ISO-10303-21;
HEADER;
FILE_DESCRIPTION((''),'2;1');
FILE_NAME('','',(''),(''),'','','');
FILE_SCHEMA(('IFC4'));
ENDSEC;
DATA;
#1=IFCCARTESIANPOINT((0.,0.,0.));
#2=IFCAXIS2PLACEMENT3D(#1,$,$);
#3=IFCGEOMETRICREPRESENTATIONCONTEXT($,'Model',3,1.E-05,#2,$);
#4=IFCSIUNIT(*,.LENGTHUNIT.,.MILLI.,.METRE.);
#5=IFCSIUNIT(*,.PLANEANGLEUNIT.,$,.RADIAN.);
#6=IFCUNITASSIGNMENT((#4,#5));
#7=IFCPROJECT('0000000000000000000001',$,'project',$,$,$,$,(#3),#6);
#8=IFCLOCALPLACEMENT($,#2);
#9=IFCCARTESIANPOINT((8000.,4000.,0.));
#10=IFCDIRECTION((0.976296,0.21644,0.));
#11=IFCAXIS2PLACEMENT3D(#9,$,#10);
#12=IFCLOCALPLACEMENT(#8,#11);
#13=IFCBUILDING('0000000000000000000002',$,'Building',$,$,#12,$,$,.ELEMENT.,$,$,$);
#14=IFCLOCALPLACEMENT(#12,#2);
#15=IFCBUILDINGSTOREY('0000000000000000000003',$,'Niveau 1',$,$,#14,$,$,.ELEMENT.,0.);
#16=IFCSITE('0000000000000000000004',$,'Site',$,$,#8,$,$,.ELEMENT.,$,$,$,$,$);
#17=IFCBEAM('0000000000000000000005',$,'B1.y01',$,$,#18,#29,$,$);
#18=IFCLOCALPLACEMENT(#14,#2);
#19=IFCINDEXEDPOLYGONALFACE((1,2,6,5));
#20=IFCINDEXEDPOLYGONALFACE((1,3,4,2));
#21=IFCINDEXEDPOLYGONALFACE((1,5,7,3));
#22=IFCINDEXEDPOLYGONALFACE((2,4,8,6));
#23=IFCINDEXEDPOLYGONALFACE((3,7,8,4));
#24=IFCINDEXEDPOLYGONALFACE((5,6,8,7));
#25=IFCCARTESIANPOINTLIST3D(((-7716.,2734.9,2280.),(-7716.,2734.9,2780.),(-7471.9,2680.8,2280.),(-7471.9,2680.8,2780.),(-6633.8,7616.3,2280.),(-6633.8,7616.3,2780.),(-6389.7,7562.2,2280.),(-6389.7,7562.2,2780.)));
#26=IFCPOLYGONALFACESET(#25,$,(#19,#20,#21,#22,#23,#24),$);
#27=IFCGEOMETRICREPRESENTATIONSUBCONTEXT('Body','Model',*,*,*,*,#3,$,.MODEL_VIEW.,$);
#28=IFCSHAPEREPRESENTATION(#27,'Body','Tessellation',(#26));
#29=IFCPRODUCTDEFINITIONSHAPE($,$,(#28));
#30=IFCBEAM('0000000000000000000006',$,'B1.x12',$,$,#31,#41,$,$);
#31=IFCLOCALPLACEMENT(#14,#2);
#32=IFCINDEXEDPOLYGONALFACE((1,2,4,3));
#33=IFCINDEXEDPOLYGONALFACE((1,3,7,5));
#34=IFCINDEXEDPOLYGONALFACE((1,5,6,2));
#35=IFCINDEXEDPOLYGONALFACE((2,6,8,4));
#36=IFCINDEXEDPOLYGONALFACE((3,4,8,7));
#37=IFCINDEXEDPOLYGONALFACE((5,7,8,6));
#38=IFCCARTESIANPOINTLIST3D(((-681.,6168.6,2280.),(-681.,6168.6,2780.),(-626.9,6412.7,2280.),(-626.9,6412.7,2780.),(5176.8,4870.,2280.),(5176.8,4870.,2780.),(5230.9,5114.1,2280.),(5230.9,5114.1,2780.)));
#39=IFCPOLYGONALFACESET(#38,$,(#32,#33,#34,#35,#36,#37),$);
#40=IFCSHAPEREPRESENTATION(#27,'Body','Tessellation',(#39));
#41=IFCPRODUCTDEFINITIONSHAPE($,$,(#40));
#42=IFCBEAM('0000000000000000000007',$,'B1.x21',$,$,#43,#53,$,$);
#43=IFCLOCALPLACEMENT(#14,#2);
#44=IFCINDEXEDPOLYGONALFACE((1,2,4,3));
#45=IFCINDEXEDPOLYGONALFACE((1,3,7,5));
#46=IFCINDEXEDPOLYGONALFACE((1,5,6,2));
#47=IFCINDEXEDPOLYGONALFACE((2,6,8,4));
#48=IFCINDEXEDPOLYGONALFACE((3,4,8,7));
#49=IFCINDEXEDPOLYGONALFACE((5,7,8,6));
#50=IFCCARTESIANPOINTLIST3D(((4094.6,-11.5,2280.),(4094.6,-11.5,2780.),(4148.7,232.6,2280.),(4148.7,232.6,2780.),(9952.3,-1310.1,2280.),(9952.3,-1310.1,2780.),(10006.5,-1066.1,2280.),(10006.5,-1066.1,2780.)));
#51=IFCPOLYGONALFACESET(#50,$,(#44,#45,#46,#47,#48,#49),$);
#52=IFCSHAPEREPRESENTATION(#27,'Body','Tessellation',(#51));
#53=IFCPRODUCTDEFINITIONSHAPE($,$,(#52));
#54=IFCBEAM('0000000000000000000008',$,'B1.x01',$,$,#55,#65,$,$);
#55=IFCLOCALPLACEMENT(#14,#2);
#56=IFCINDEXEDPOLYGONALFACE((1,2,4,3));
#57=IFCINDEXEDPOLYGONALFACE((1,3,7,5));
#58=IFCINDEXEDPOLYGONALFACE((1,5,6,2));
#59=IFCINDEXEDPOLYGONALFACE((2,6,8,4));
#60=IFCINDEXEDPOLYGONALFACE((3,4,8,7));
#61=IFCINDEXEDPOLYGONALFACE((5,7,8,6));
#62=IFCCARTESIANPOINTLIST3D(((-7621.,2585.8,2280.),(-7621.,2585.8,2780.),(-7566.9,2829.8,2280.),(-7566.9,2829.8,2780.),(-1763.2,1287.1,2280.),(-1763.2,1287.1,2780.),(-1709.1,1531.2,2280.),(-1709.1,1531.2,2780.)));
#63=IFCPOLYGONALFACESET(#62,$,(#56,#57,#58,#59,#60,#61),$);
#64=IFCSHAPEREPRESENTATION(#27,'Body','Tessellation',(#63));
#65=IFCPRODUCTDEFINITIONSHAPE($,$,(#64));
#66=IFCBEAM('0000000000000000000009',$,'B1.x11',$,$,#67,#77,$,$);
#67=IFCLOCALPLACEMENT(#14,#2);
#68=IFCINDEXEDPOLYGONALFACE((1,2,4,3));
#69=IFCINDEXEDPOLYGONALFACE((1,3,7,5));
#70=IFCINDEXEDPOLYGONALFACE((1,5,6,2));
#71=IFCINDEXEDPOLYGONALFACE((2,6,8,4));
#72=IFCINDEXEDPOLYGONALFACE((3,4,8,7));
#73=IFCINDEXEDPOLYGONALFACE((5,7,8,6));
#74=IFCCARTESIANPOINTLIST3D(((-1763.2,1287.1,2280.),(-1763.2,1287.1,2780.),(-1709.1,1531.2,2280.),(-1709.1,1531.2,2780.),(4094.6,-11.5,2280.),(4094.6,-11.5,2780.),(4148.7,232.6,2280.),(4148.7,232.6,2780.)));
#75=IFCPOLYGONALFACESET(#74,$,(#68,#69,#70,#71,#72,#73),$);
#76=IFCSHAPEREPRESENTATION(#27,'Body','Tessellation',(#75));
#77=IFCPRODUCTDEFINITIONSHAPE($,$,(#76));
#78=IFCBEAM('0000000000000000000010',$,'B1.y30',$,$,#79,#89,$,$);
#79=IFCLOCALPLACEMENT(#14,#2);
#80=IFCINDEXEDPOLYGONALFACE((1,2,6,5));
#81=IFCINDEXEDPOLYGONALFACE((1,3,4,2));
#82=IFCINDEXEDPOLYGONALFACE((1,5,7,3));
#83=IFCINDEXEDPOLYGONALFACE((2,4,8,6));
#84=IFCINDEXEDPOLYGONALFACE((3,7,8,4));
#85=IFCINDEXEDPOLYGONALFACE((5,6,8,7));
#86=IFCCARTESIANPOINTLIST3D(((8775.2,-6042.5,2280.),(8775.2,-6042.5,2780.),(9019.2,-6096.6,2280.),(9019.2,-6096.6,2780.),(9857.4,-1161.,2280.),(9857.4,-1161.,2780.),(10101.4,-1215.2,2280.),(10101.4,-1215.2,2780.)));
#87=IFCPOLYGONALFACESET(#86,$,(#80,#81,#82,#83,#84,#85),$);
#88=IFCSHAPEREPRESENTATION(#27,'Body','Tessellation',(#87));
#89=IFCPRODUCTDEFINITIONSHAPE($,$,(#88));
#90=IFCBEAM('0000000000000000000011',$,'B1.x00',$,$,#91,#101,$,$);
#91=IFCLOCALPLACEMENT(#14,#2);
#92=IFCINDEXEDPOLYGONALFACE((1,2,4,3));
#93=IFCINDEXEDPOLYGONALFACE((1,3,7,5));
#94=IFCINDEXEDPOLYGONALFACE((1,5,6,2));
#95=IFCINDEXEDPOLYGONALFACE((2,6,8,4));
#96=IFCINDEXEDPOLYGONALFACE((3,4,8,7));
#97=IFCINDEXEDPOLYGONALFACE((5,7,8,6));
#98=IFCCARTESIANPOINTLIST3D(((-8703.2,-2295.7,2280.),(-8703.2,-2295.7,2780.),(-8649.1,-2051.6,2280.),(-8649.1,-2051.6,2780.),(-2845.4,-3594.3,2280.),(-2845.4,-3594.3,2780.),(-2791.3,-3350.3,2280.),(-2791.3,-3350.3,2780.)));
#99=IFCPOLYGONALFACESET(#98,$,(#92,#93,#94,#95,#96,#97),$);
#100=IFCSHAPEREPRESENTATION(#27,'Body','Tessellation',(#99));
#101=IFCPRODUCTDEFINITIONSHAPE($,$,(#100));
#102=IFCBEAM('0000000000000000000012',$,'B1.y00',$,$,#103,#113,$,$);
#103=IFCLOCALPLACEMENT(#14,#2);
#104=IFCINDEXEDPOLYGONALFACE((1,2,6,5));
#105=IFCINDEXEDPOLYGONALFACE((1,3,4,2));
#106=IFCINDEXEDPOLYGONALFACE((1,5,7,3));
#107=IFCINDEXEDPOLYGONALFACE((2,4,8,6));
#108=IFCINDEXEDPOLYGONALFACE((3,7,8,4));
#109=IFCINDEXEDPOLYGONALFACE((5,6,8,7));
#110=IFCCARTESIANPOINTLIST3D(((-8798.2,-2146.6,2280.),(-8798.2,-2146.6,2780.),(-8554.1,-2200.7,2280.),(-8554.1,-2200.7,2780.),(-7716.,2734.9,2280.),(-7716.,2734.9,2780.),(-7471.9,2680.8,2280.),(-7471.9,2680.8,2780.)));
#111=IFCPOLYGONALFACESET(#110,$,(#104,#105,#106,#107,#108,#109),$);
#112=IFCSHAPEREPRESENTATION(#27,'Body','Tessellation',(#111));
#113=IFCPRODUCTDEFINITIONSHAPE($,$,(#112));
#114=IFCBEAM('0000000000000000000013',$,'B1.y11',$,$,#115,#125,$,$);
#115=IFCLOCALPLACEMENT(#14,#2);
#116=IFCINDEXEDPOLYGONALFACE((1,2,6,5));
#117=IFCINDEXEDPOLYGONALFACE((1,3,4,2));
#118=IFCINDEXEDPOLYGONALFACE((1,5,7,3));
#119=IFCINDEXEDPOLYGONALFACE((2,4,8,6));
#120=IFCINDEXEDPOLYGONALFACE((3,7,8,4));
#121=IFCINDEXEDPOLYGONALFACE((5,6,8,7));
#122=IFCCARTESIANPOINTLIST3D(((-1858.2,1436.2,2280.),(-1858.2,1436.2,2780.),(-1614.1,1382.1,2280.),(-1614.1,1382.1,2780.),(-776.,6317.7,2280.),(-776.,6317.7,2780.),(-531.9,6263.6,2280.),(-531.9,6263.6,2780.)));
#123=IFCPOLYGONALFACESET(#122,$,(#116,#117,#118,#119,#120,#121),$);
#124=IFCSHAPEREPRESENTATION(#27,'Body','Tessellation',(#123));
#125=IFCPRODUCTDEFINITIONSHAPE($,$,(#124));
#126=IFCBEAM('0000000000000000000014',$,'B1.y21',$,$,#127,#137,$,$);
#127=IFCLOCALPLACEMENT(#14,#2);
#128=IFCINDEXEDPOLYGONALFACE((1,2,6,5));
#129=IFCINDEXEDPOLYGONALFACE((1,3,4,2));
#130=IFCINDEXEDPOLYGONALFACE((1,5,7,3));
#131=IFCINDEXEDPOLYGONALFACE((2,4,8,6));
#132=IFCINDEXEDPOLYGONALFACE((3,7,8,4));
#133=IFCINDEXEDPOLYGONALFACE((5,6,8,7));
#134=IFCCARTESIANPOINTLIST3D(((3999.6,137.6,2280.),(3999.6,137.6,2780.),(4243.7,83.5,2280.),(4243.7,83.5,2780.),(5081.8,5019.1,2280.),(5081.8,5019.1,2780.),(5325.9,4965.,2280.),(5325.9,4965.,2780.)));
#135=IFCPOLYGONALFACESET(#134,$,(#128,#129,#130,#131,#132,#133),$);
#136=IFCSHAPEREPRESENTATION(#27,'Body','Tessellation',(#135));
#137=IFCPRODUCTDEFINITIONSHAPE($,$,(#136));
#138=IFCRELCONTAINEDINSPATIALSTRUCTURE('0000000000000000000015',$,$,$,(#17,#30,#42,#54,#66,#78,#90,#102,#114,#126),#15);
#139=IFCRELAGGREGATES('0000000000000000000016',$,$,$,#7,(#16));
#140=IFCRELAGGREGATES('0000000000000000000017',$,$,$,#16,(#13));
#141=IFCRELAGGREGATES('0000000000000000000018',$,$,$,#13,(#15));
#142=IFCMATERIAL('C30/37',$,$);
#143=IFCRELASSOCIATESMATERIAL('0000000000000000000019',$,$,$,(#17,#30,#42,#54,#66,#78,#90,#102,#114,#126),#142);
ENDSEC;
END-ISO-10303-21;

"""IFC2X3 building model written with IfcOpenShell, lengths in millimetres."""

from ifc_helpers import new_model, si_unit, frame, origin, origin_2d, place, context, subcontext, project, spatial, rectangle, extrude, material, element, save


model = new_model("IFC2X3")

# Units and contexts
model_context = context("Model", 3, precision=1e-05, world=origin())
body_context = subcontext(model_context, "Body", "Model", "MODEL_VIEW")
ifc_project = project(units=[si_unit("LENGTHUNIT", "METRE", prefix="MILLI"), si_unit("PLANEANGLEUNIT", "RADIAN")], contexts=[model_context])

# Site, building, storey
site_placement = place(None, origin())
site = spatial("IfcSite", under=ifc_project, at=site_placement, Name="Site", CompositionType="ELEMENT")
building_placement = place(site_placement, frame((8000.0, 4000.0, 0.0), x_axis=(0.976296, 0.21644, 0.0)))
building = spatial("IfcBuilding", under=site, at=building_placement, Name="Building", CompositionType="ELEMENT")
storey_placement = place(building_placement, origin())
storey = spatial("IfcBuildingStorey", under=building, at=storey_placement, Name="Niveau 1", CompositionType="ELEMENT", Elevation=0.0)

# Shared definitions
ifc_material = material(Name="C30/37")

# Beams
beam_1_placement = place(storey_placement, frame((-7593.9, 2707.8, 2530.0), z_axis=(0.21644, 0.976296, 0.0), x_axis=(-0.976296, 0.21644, 0.0)))
element("IfcBeam", 1, at=beam_1_placement, inside=storey, material=ifc_material, Name="B1.y01", context=body_context, shape_type="SweptSolid", body=[
    extrude(rectangle(XDim=250.0, YDim=500.0, at=origin_2d()), origin(), (0.0, 0.0, 1.0), 5000.0),
])
for number, where, z_axis, x_axis, name in (
    (2, (-654.0, 6290.7, 2530.0), (0.976296, -0.21644, 0.0), (0.21644, 0.976296, 0.0), "B1.x12"),
    (3, (4121.6, 110.5, 2530.0), (0.976296, -0.21644, 0.0), (0.21644, 0.976296, 0.0), "B1.x21"),
    (4, (-7593.9, 2707.8, 2530.0), (0.976296, -0.21644, 0.0), (0.21644, 0.976296, 0.0), "B1.x01"),
    (5, (-1736.2, 1409.2, 2530.0), (0.976296, -0.21644, 0.0), (0.21644, 0.976296, 0.0), "B1.x11"),
):
    element("IfcBeam", number, at=place(storey_placement, frame(where, z_axis=z_axis, x_axis=x_axis)), inside=storey, material=ifc_material, Name=name, context=body_context, shape_type="SweptSolid", body=[
        extrude(rectangle(XDim=250.0, YDim=500.0, at=origin_2d()), origin(), (0.0, 0.0, 1.0), 6000.0),
    ])
beam_2_placement = place(storey_placement, frame((8897.2, -6069.6, 2530.0), z_axis=(0.21644, 0.976296, 0.0), x_axis=(-0.976296, 0.21644, 0.0)))
element("IfcBeam", 6, at=beam_2_placement, inside=storey, material=ifc_material, Name="B1.y30", context=body_context, shape_type="SweptSolid", body=[
    extrude(rectangle(XDim=250.0, YDim=500.0, at=origin_2d()), origin(), (0.0, 0.0, 1.0), 5000.0),
])
beam_3_placement = place(storey_placement, frame((-8676.1, -2173.7, 2530.0), z_axis=(0.976296, -0.21644, 0.0), x_axis=(0.21644, 0.976296, 0.0)))
element("IfcBeam", 7, at=beam_3_placement, inside=storey, material=ifc_material, Name="B1.x00", context=body_context, shape_type="SweptSolid", body=[
    extrude(rectangle(XDim=250.0, YDim=500.0, at=origin_2d()), origin(), (0.0, 0.0, 1.0), 6000.0),
])
for number, where, z_axis, x_axis, name in (
    (8, (-8676.1, -2173.7, 2530.0), (0.21644, 0.976296, 0.0), (-0.976296, 0.21644, 0.0), "B1.y00"),
    (9, (-1736.2, 1409.2, 2530.0), (0.21644, 0.976296, 0.0), (-0.976296, 0.21644, 0.0), "B1.y11"),
    (10, (4121.6, 110.5, 2530.0), (0.21644, 0.976296, 0.0), (-0.976296, 0.21644, 0.0), "B1.y21"),
):
    element("IfcBeam", number, at=place(storey_placement, frame(where, z_axis=z_axis, x_axis=x_axis)), inside=storey, material=ifc_material, Name=name, context=body_context, shape_type="SweptSolid", body=[
        extrude(rectangle(XDim=250.0, YDim=500.0, at=origin_2d()), origin(), (0.0, 0.0, 1.0), 5000.0),
    ])

save(model, "model.ifc")
